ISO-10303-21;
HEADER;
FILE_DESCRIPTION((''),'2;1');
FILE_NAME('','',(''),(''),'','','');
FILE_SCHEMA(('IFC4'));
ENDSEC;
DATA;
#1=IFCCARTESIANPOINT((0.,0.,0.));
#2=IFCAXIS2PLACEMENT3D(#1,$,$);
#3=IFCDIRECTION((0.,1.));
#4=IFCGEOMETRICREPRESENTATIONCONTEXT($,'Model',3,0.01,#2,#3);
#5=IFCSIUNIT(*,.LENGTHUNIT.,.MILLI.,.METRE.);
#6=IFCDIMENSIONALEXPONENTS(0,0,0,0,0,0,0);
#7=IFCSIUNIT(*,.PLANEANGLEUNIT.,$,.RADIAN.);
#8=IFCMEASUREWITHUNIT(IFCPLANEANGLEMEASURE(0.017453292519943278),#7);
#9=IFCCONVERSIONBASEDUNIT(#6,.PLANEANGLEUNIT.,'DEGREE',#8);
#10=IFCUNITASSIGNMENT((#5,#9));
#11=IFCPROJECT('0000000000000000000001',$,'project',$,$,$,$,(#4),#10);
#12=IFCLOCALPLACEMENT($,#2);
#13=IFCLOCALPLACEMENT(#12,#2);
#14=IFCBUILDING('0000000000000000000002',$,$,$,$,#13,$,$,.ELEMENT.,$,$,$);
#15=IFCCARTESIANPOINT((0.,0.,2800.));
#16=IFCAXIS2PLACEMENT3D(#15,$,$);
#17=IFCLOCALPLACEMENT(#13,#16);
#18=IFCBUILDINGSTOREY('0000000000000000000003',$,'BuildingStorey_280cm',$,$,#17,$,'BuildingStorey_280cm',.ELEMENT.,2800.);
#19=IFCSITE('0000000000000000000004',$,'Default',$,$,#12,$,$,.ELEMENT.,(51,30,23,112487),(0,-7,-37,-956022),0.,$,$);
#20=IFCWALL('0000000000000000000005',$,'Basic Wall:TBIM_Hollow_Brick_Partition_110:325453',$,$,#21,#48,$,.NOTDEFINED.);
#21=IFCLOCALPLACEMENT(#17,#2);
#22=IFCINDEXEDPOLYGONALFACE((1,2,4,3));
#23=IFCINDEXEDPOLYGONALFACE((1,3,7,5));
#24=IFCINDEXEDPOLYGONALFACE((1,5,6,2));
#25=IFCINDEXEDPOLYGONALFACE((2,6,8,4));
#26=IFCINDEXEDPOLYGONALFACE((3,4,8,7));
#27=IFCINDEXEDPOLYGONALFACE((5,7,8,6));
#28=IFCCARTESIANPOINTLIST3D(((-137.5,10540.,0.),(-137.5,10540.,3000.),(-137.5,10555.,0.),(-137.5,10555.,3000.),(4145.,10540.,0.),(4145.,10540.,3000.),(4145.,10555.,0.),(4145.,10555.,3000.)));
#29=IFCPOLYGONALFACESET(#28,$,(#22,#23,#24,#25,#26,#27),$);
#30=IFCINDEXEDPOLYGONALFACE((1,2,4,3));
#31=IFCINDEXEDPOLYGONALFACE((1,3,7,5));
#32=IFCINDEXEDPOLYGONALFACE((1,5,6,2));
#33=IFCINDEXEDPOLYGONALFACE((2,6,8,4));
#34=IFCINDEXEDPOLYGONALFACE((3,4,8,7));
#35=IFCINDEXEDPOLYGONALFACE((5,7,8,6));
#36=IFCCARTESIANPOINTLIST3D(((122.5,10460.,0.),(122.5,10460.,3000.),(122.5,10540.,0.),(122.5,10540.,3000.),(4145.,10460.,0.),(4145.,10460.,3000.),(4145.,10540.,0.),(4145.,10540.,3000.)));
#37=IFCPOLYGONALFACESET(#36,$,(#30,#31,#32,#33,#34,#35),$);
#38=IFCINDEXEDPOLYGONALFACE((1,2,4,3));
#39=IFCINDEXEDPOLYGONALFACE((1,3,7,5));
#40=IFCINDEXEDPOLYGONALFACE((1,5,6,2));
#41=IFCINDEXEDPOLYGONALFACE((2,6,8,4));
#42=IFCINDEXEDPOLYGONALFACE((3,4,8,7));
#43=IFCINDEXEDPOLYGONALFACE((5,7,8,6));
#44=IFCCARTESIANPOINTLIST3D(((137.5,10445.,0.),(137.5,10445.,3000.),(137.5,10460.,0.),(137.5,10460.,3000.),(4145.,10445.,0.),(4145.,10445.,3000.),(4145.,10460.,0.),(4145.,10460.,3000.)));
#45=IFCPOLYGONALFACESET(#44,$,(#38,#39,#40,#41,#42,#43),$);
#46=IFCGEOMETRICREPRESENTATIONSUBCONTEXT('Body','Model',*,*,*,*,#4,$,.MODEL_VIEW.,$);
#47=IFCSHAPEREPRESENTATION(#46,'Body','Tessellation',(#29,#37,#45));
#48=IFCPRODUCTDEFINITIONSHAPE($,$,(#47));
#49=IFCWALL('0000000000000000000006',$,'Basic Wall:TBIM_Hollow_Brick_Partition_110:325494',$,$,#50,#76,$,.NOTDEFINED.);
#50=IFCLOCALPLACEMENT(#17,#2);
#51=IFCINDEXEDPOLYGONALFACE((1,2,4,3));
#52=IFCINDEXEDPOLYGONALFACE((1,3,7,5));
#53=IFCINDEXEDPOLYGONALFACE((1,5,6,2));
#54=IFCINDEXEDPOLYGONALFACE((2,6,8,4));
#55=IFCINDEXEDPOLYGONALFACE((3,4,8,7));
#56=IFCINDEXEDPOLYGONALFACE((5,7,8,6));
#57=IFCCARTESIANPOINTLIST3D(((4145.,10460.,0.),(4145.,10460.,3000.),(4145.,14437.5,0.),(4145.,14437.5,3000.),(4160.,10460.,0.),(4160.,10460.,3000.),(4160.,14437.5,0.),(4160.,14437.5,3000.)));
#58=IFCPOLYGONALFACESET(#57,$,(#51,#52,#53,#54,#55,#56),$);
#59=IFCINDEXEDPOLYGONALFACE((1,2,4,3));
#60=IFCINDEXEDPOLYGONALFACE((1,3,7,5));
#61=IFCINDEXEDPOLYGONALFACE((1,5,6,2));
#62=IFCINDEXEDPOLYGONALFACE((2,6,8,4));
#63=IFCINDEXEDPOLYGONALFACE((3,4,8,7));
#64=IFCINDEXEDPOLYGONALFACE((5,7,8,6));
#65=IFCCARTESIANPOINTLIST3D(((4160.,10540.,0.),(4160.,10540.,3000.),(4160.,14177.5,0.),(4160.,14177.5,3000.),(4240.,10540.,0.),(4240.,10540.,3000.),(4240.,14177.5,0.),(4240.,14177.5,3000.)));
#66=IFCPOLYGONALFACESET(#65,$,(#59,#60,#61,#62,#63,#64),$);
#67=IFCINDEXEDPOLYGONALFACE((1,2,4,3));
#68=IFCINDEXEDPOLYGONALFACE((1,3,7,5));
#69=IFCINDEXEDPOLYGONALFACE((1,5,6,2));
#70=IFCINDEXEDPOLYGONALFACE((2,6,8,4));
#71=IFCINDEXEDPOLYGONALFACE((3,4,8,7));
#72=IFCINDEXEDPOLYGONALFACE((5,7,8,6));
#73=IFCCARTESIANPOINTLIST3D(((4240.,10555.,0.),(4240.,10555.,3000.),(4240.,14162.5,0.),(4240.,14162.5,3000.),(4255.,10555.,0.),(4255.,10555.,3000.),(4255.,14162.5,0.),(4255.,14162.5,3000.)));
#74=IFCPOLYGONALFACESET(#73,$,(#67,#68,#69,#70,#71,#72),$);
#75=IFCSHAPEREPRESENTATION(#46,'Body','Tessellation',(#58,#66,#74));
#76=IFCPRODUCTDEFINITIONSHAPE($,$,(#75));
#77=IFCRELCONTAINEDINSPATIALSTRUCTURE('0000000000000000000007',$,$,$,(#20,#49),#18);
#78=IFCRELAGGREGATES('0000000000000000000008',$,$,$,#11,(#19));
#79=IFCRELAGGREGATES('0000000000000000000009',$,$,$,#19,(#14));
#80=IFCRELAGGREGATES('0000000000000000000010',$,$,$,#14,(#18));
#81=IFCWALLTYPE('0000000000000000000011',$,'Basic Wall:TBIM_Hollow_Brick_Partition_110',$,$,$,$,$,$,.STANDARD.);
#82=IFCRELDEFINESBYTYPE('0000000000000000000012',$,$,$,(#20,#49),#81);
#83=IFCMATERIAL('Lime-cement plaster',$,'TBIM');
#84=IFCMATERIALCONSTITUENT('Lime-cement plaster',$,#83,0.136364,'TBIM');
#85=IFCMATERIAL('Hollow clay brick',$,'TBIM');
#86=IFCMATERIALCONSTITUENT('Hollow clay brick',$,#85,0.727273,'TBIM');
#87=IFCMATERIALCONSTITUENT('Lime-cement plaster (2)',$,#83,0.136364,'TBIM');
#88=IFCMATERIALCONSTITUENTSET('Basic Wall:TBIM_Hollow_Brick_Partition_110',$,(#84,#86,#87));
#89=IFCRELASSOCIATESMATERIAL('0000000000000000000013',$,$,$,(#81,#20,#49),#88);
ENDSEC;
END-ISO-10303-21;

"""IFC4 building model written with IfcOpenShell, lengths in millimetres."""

from ifc_helpers import new_model, entity, si_unit, converted_unit, direction, frame, origin, place, context, subcontext, project, spatial, indexed_curve, outline, extrude, material, constituent, constituent_set, type_object, element, save


model = new_model("IFC4")

# Units and contexts
model_context = context("Model", 3, precision=0.01, world=origin(), true_north=direction((0.0, 1.0)))
body_context = subcontext(model_context, "Body", "Model", "MODEL_VIEW")
ifc_project = project(units=[si_unit("LENGTHUNIT", "METRE", prefix="MILLI"), converted_unit("PLANEANGLEUNIT", "DEGREE", entity("IfcPlaneAngleMeasure", 0.017453292519943278), si_unit("PLANEANGLEUNIT", "RADIAN"), dimensions=[0, 0, 0, 0, 0, 0, 0])], contexts=[model_context])

# Site, building, storey
site_placement = place(None, origin())
site = spatial("IfcSite", under=ifc_project, at=site_placement, Name="Default", CompositionType="ELEMENT", RefLatitude=(51, 30, 23, 112487), RefLongitude=(0, -7, -37, -956022), RefElevation=0.0)
building_placement = place(site_placement, origin())
building = spatial("IfcBuilding", under=site, at=building_placement, CompositionType="ELEMENT")
storey_placement = place(building_placement, frame((0.0, 0.0, 2800.0)))
storey = spatial("IfcBuildingStorey", under=building, at=storey_placement, Name="BuildingStorey_280cm", LongName="BuildingStorey_280cm", CompositionType="ELEMENT", Elevation=2800.0)

# Shared definitions
ifc_material_1 = material(Name="Lime-cement plaster", Category="TBIM")

# Shared definitions
ifc_material_2 = material(Name="Hollow clay brick", Category="TBIM")

# Shared definitions
ifc_constituent_1 = constituent(ifc_material_1, Name="Lime-cement plaster", Category="TBIM", fraction=0.136364)
ifc_constituent_2 = constituent(ifc_material_2, Name="Hollow clay brick", Category="TBIM", fraction=0.727273)
ifc_constituent_3 = constituent(ifc_material_1, Name="Lime-cement plaster (2)", Category="TBIM", fraction=0.136364)
ifc_constituent_set_1 = constituent_set(constituents=[ifc_constituent_1, ifc_constituent_2, ifc_constituent_3], Name="Basic Wall:TBIM_Hollow_Brick_Partition_110")
wall_type_1 = type_object("IfcWallType", Name="Basic Wall:TBIM_Hollow_Brick_Partition_110", PredefinedType="STANDARD", material=ifc_constituent_set_1)

# Walls
wall_1_placement = place(storey_placement, frame((137.5, 10500.0, 0.0)))
element("IfcWall", 1, at=wall_1_placement, inside=storey, type_object=wall_type_1, material=ifc_constituent_set_1, Name="Basic Wall:TBIM_Hollow_Brick_Partition_110:325453", PredefinedType="NOTDEFINED", context=body_context, shape_type="SweptSolid", body=[
    extrude(outline(indexed_curve([(-7.5, -2141.2), (7.5, -2141.2), (7.5, 2141.2), (-7.5, 2141.2), (-7.5, -2141.2)], self_intersect=False)), frame((1866.2, 47.5, 0.0), z_axis=(0.0, 0.0, 1.0), x_axis=(0.0, -1.0, 0.0)), (0.0, 0.0, 1.0), 3000.0),
    extrude(outline(indexed_curve([(-2011.2, -40.0), (2011.2, -40.0), (2011.2, 40.0), (-2011.2, 40.0), (-2011.2, -40.0)], self_intersect=False)), frame((1996.2, 0.0, 0.0)), (0.0, 0.0, 1.0), 3000.0),
    extrude(outline(indexed_curve([(-7.5, -2003.7), (7.5, -2003.7), (7.5, 2003.7), (-7.5, 2003.7), (-7.5, -2003.7)], self_intersect=False)), frame((2003.7, -47.5, 0.0), z_axis=(0.0, 0.0, 1.0), x_axis=(0.0, 1.0, 0.0)), (0.0, 0.0, 1.0), 3000.0),
])
wall_2_placement = place(storey_placement, frame((4200.0, 10555.0, 0.0), z_axis=(0.0, 0.0, 1.0), x_axis=(0.0, 1.0, 0.0)))
element("IfcWall", 2, at=wall_2_placement, inside=storey, type_object=wall_type_1, material=ifc_constituent_set_1, Name="Basic Wall:TBIM_Hollow_Brick_Partition_110:325494", PredefinedType="NOTDEFINED", context=body_context, shape_type="SweptSolid", body=[
    extrude(outline(indexed_curve([(-7.5, -1988.8), (7.5, -1988.8), (7.5, 1988.8), (-7.5, 1988.8), (-7.5, -1988.8)], self_intersect=False)), frame((1893.8, 47.5, 0.0), z_axis=(0.0, 0.0, 1.0), x_axis=(0.0, -1.0, 0.0)), (0.0, 0.0, 1.0), 3000.0),
    extrude(outline(indexed_curve([(-1818.8, -40.0), (1818.8, -40.0), (1818.8, 40.0), (-1818.8, 40.0), (-1818.8, -40.0)], self_intersect=False)), frame((1803.7, 0.0, 0.0)), (0.0, 0.0, 1.0), 3000.0),
    extrude(outline(indexed_curve([(-7.5, -1803.8), (7.5, -1803.8), (7.5, 1803.7), (-7.5, 1803.7), (-7.5, -1803.8)], self_intersect=False)), frame((1803.7, -47.5, 0.0), z_axis=(0.0, 0.0, 1.0), x_axis=(0.0, 1.0, 0.0)), (0.0, 0.0, 1.0), 3000.0),
])

save(model, "model.ifc")
